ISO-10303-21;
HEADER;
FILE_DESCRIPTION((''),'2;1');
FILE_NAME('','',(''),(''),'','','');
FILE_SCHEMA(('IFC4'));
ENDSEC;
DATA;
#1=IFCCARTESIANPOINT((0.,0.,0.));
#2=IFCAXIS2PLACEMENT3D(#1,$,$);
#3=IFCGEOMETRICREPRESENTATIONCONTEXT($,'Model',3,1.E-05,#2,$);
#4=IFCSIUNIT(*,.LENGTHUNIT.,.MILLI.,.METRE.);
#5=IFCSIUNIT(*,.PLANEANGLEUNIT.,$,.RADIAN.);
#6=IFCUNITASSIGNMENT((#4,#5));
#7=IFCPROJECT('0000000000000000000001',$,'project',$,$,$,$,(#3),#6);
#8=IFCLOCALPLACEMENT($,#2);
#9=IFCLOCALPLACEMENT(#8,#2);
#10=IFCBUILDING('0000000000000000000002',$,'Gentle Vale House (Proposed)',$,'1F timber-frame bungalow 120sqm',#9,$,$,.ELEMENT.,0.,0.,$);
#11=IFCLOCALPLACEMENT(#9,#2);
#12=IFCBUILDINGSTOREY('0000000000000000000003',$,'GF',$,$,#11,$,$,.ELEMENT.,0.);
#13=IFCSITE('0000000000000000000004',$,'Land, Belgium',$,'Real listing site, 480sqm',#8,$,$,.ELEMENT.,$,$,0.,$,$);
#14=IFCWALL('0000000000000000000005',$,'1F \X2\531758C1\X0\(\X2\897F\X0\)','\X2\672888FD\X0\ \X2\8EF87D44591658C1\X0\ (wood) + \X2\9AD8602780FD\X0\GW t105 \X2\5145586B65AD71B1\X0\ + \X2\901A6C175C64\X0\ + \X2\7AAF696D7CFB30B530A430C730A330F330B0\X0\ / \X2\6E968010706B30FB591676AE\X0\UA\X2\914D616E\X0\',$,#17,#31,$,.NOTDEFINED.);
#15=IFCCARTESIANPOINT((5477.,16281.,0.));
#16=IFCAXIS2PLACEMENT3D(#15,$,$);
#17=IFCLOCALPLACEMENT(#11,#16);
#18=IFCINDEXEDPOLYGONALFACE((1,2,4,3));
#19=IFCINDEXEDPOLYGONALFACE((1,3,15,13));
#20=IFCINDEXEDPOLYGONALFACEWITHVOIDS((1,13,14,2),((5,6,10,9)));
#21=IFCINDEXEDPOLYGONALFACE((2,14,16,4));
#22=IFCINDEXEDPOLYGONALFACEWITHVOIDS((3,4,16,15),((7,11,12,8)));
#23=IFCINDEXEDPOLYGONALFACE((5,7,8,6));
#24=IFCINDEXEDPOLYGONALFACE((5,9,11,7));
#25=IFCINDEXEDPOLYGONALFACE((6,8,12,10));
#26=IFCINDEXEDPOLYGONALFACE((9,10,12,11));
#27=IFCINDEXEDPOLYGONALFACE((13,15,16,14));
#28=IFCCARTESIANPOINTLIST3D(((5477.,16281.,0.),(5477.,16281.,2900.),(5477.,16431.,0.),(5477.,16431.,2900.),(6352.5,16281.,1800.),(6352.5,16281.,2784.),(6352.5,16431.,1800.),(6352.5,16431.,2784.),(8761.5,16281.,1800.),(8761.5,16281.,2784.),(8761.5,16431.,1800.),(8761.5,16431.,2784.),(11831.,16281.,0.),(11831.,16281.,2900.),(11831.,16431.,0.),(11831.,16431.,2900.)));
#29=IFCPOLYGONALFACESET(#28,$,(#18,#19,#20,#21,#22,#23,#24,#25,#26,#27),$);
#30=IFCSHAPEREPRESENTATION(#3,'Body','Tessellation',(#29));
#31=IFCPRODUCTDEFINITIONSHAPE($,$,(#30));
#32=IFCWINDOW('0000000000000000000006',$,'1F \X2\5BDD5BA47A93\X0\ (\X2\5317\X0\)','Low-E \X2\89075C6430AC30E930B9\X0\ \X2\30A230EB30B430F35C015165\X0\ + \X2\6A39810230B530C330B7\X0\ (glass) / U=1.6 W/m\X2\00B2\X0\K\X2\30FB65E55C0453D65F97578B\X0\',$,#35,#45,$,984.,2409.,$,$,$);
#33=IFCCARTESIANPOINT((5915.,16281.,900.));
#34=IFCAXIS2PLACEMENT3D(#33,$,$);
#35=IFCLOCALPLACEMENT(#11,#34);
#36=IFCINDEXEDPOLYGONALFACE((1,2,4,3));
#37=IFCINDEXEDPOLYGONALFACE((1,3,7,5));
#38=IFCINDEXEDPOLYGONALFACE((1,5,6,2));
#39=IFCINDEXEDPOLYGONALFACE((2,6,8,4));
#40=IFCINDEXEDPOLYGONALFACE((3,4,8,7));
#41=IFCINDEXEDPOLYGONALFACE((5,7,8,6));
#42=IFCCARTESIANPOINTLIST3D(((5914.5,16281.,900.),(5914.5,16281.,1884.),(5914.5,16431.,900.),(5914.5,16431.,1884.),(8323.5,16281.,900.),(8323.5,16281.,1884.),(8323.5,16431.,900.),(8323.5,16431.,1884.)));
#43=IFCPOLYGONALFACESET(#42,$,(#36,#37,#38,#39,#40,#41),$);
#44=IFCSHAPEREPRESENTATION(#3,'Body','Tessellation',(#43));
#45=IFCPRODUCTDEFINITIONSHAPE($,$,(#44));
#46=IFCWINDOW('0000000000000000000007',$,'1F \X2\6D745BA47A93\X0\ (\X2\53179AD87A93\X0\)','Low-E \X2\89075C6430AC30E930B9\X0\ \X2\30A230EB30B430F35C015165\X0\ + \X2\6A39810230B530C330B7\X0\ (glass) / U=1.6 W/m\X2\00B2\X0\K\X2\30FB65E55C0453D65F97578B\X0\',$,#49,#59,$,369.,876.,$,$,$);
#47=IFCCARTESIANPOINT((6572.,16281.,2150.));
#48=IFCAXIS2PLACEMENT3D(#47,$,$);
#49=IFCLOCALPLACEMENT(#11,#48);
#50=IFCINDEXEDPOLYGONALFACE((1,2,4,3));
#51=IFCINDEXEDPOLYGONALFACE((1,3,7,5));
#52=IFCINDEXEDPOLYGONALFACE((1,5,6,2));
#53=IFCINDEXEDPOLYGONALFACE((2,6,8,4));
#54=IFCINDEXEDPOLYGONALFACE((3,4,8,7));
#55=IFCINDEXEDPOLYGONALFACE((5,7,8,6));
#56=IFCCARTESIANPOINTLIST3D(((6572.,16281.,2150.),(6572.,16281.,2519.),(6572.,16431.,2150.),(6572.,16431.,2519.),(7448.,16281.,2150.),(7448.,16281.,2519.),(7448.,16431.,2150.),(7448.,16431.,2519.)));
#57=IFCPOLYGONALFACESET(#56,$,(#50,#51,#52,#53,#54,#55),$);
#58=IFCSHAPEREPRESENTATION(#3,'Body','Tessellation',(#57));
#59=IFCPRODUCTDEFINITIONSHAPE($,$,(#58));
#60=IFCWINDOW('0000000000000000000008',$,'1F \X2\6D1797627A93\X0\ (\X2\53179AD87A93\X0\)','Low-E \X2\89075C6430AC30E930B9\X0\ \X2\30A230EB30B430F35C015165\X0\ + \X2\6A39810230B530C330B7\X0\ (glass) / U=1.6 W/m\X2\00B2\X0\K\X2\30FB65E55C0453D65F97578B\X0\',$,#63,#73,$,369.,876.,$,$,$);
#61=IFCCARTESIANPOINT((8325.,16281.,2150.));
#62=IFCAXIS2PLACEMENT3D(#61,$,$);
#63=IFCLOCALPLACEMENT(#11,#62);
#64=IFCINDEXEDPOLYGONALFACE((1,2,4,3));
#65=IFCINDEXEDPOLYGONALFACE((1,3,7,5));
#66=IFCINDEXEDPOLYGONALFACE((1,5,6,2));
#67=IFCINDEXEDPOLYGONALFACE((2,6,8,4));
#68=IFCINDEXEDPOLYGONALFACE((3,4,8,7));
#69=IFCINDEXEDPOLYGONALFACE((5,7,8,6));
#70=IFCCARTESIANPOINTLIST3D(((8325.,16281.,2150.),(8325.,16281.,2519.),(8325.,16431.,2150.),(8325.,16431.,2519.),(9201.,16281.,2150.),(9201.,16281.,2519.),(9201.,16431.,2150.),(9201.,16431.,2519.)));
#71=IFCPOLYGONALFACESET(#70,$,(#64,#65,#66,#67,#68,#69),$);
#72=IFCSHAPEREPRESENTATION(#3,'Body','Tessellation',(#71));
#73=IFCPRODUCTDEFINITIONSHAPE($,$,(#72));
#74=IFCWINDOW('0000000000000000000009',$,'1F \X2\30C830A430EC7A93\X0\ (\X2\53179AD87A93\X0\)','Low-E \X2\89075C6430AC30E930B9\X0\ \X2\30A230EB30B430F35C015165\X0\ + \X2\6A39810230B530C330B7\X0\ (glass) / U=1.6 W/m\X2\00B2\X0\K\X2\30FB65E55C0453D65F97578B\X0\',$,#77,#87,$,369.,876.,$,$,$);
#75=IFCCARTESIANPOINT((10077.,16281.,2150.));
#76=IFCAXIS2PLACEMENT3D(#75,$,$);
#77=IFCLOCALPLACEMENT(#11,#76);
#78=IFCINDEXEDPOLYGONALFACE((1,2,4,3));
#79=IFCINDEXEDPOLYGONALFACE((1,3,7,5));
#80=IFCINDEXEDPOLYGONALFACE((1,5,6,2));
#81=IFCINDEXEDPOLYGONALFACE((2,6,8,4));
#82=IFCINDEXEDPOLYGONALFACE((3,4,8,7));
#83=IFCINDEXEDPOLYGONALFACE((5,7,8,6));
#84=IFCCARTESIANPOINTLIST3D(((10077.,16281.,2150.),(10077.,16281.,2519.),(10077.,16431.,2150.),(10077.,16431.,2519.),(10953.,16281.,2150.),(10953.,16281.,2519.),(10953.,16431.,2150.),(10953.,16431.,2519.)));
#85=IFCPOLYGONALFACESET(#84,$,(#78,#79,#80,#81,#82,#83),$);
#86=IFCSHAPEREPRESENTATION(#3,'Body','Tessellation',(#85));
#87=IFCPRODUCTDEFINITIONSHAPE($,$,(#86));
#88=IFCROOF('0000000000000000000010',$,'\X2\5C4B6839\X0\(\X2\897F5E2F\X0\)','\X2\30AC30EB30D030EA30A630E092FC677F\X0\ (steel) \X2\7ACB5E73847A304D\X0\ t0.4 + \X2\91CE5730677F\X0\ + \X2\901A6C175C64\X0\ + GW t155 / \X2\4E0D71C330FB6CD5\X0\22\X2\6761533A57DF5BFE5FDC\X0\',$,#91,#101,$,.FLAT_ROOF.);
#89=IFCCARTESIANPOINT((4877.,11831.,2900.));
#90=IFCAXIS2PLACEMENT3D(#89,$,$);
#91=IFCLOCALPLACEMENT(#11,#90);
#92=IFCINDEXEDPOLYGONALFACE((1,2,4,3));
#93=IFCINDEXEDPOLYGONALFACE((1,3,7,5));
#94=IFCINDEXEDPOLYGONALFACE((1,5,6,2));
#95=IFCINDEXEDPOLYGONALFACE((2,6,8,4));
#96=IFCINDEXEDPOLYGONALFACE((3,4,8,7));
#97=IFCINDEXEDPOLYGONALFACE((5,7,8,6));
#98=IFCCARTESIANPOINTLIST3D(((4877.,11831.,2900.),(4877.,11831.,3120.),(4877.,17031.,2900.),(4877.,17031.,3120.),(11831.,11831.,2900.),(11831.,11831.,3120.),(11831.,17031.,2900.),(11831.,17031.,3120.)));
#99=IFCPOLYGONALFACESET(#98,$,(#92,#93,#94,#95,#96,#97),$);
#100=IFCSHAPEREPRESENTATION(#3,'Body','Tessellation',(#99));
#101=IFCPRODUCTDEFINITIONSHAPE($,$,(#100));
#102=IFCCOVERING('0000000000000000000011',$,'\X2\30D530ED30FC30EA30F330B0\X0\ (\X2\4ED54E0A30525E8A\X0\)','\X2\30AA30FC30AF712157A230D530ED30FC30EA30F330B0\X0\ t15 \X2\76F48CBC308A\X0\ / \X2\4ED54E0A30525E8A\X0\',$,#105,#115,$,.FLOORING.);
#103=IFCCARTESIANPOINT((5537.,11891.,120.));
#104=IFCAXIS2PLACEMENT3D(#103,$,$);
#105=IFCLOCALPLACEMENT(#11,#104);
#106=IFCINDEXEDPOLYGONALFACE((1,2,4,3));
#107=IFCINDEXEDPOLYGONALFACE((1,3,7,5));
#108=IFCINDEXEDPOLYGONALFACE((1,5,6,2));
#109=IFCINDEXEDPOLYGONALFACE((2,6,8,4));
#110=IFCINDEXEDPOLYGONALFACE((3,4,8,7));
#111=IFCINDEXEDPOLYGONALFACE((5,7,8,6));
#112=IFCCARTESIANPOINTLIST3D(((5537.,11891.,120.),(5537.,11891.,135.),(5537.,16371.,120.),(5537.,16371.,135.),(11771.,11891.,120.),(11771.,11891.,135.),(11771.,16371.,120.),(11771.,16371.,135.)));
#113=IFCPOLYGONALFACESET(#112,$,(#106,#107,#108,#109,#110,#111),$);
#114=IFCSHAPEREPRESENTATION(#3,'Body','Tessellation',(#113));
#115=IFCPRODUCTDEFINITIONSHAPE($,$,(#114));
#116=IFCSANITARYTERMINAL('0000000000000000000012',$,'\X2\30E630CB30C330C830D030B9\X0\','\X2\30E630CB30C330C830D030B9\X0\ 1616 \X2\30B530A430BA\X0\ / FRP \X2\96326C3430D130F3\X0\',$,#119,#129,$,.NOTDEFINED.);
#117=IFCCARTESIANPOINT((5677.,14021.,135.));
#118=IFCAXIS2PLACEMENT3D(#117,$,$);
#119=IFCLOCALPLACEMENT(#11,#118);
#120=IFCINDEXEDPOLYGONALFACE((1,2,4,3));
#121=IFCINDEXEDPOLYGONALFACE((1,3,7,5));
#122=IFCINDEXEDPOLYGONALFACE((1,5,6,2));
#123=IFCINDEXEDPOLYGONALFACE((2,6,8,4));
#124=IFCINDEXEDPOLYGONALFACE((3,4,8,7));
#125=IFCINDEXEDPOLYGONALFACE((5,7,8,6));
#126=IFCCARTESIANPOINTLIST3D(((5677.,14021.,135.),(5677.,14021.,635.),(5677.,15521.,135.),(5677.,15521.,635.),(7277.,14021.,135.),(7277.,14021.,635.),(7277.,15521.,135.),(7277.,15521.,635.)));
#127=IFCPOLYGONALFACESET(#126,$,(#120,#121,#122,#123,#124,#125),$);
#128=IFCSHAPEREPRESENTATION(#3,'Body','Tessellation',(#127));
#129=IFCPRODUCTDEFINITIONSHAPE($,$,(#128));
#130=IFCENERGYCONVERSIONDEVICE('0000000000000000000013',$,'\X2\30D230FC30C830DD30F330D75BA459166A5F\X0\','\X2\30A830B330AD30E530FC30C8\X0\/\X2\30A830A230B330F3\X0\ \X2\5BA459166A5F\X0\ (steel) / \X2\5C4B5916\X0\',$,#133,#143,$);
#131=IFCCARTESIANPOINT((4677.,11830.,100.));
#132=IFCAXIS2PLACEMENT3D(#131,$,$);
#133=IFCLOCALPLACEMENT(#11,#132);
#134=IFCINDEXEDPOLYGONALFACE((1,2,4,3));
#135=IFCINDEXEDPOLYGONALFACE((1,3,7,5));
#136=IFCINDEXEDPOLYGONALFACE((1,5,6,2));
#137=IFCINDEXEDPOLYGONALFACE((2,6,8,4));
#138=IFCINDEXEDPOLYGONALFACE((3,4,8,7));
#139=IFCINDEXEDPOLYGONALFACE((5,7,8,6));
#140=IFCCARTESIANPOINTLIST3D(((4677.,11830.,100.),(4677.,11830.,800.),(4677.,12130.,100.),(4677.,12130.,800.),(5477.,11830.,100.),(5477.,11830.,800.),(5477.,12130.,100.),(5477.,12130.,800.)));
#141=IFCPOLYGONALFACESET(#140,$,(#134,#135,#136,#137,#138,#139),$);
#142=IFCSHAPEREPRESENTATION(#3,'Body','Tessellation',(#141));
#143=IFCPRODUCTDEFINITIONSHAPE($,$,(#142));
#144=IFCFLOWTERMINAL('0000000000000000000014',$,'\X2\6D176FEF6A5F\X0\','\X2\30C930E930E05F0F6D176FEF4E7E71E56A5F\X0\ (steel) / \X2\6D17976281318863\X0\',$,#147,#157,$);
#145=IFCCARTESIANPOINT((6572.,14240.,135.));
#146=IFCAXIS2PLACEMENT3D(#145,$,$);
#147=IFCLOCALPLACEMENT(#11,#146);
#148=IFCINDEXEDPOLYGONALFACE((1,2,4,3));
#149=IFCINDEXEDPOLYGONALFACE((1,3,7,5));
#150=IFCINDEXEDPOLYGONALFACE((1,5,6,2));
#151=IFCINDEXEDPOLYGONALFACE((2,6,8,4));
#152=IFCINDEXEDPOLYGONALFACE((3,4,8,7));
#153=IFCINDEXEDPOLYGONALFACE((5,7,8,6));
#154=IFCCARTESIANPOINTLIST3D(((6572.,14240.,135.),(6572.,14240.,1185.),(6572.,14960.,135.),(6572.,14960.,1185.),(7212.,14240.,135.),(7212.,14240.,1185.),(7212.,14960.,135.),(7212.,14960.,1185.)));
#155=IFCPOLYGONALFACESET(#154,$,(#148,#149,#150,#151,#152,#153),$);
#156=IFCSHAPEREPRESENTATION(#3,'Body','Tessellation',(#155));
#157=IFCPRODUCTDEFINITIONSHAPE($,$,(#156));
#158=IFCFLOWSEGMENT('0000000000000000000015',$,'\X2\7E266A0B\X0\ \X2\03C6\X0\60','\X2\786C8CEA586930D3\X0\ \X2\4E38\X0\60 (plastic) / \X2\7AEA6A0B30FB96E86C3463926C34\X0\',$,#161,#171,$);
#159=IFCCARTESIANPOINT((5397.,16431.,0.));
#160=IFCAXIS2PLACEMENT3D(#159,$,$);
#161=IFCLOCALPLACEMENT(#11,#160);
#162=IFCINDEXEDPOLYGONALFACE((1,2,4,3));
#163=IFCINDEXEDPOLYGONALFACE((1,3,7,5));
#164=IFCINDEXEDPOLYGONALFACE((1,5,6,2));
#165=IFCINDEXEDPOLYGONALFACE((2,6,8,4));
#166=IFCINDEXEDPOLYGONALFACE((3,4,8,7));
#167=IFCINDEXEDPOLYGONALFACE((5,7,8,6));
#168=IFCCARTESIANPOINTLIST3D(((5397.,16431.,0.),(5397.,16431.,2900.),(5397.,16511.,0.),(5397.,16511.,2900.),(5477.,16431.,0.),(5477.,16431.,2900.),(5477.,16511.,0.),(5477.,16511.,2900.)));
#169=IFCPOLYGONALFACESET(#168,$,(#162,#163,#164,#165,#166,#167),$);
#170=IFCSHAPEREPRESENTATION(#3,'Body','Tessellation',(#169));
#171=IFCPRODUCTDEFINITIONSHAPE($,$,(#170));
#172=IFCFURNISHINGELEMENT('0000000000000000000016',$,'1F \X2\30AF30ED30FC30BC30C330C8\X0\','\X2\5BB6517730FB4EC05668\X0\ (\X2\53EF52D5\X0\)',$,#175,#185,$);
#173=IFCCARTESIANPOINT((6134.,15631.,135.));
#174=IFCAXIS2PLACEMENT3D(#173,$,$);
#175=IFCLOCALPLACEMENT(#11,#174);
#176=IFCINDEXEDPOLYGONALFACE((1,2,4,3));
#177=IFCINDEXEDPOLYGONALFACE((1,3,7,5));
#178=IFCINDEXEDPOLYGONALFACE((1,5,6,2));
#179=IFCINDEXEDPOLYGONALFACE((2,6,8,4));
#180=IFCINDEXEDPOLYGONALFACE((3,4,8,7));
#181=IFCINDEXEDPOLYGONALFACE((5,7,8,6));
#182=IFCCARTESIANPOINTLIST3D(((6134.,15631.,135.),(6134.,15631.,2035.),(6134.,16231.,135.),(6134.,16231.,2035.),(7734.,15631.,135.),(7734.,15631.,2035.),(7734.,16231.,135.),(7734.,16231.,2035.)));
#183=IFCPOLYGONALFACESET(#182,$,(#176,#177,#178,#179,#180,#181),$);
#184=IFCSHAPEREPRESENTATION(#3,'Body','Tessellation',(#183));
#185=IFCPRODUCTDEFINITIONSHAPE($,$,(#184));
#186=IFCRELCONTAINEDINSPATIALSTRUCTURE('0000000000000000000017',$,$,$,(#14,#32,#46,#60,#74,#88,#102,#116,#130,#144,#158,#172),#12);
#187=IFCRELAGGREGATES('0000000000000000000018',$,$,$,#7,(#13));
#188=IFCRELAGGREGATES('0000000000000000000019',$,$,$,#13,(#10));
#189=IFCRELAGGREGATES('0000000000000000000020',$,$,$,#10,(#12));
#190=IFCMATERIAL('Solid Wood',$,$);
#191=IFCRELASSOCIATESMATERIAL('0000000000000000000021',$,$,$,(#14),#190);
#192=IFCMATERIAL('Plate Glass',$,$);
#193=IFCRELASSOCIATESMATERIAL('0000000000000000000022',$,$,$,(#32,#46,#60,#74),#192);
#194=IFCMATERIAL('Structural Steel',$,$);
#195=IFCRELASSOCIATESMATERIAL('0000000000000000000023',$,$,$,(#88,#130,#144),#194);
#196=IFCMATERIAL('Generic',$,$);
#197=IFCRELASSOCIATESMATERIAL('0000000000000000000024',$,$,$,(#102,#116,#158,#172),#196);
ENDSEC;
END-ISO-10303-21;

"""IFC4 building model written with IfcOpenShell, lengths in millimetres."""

from ifc_helpers import new_model, si_unit, frame, frame_2d, origin, place, context, project, spatial, rectangle, extrude, material, element, fill, save


model = new_model("IFC4")

# Units and contexts
model_context = context("Model", 3, precision=1e-05, world=origin())
ifc_project = project(units=[si_unit("LENGTHUNIT", "METRE", prefix="MILLI"), si_unit("PLANEANGLEUNIT", "RADIAN")], contexts=[model_context])

# Site, building, storey
site_placement = place(None, origin())
site = spatial("IfcSite", under=ifc_project, at=site_placement, Name="Land, Belgium", ObjectType="Real listing site, 480sqm", CompositionType="ELEMENT", RefElevation=0.0)
building_placement = place(site_placement, origin())
building = spatial("IfcBuilding", under=site, at=building_placement, Name="Gentle Vale House (Proposed)", ObjectType="1F timber-frame bungalow 120sqm", CompositionType="ELEMENT", ElevationOfRefHeight=0.0, ElevationOfTerrain=0.0)
storey_placement = place(building_placement, origin())
storey = spatial("IfcBuildingStorey", under=building, at=storey_placement, Name="GF", CompositionType="ELEMENT", Elevation=0.0)

# Shared definitions
ifc_material_1 = material(Name="Solid Wood")

# Wall, openings, windows
wall_1_placement = place(storey_placement, frame((5477.0, 16281.0, 0.0)))
wall_1 = element("IfcWall", 1, at=wall_1_placement, inside=storey, material=ifc_material_1, Name="1F 北壁(西)", Description="木製 軸組外壁 (wood) + 高性能GW t105 充填断熱 + 通気層 + 窯業系サイディング / 準耐火・外皮UA配慮", PredefinedType="NOTDEFINED", context=model_context, shape_type="SweptSolid", body=[
    extrude(rectangle(XDim=6354.0, YDim=150.0, at=frame_2d((3177.0, 75.0))), frame((5477.0, 16281.0, 0.0)), (0.0, 0.0, 1.0), 2900.0),
])
opening_1_placement = place(storey_placement, frame((5915.0, 16281.0, 900.0)))
opening_1 = element("IfcOpeningElement", 2, at=opening_1_placement, cuts=wall_1, PredefinedType="NOTDEFINED", context=model_context, shape_type="SweptSolid", body=[
    extrude(rectangle(XDim=2409.0, YDim=150.0, at=frame_2d((1204.0, 75.0))), frame((5915.0, 16281.0, 900.0)), (0.0, 0.0, 1.0), 984.0),
])
opening_2_placement = place(storey_placement, frame((6572.0, 16281.0, 2150.0)))
opening_2 = element("IfcOpeningElement", 3, at=opening_2_placement, cuts=wall_1, PredefinedType="NOTDEFINED", context=model_context, shape_type="SweptSolid", body=[
    extrude(rectangle(XDim=876.0, YDim=150.0, at=frame_2d((438.0, 75.0))), frame((6572.0, 16281.0, 2150.0)), (0.0, 0.0, 1.0), 369.0),
])
opening_3_placement = place(storey_placement, frame((8325.0, 16281.0, 2150.0)))
opening_3 = element("IfcOpeningElement", 4, at=opening_3_placement, cuts=wall_1, PredefinedType="NOTDEFINED", context=model_context, shape_type="SweptSolid", body=[
    extrude(rectangle(XDim=876.0, YDim=150.0, at=frame_2d((438.0, 75.0))), frame((8325.0, 16281.0, 2150.0)), (0.0, 0.0, 1.0), 369.0),
])
opening_4_placement = place(storey_placement, frame((10077.0, 16281.0, 2150.0)))
opening_4 = element("IfcOpeningElement", 5, at=opening_4_placement, cuts=wall_1, PredefinedType="NOTDEFINED", context=model_context, shape_type="SweptSolid", body=[
    extrude(rectangle(XDim=876.0, YDim=150.0, at=frame_2d((438.0, 75.0))), frame((10077.0, 16281.0, 2150.0)), (0.0, 0.0, 1.0), 369.0),
])
ifc_material_2 = material(Name="Plate Glass")
window_1_placement = place(storey_placement, frame((5915.0, 16281.0, 900.0)))
window_1 = element("IfcWindow", 6, at=window_1_placement, inside=storey, material=ifc_material_2, Name="1F 寝室窓 (北)", Description="Low-E 複層ガラス アルゴン封入 + 樹脂サッシ (glass) / U=1.6 W/m²K・日射取得型", OverallHeight=984.0, OverallWidth=2409.0, context=model_context, shape_type="SweptSolid", body=[
    extrude(rectangle(XDim=2409.0, YDim=150.0, at=frame_2d((1204.0, 75.0))), frame((5915.0, 16281.0, 900.0)), (0.0, 0.0, 1.0), 984.0),
])
fill(opening_1, window_1)
window_2_placement = place(storey_placement, frame((6572.0, 16281.0, 2150.0)))
window_2 = element("IfcWindow", 7, at=window_2_placement, inside=storey, material=ifc_material_2, Name="1F 浴室窓 (北高窓)", Description="Low-E 複層ガラス アルゴン封入 + 樹脂サッシ (glass) / U=1.6 W/m²K・日射取得型", OverallHeight=369.0, OverallWidth=876.0, context=model_context, shape_type="SweptSolid", body=[
    extrude(rectangle(XDim=876.0, YDim=150.0, at=frame_2d((438.0, 75.0))), frame((6572.0, 16281.0, 2150.0)), (0.0, 0.0, 1.0), 369.0),
])
fill(opening_2, window_2)
window_3_placement = place(storey_placement, frame((8325.0, 16281.0, 2150.0)))
window_3 = element("IfcWindow", 8, at=window_3_placement, inside=storey, material=ifc_material_2, Name="1F 洗面窓 (北高窓)", Description="Low-E 複層ガラス アルゴン封入 + 樹脂サッシ (glass) / U=1.6 W/m²K・日射取得型", OverallHeight=369.0, OverallWidth=876.0, context=model_context, shape_type="SweptSolid", body=[
    extrude(rectangle(XDim=876.0, YDim=150.0, at=frame_2d((438.0, 75.0))), frame((8325.0, 16281.0, 2150.0)), (0.0, 0.0, 1.0), 369.0),
])
fill(opening_3, window_3)
window_4_placement = place(storey_placement, frame((10077.0, 16281.0, 2150.0)))
window_4 = element("IfcWindow", 9, at=window_4_placement, inside=storey, material=ifc_material_2, Name="1F トイレ窓 (北高窓)", Description="Low-E 複層ガラス アルゴン封入 + 樹脂サッシ (glass) / U=1.6 W/m²K・日射取得型", OverallHeight=369.0, OverallWidth=876.0, context=model_context, shape_type="SweptSolid", body=[
    extrude(rectangle(XDim=876.0, YDim=150.0, at=frame_2d((438.0, 75.0))), frame((10077.0, 16281.0, 2150.0)), (0.0, 0.0, 1.0), 369.0),
])
fill(opening_4, window_4)

# Roof
ifc_material_3 = material(Name="Structural Steel")
roof_placement = place(storey_placement, frame((4877.0, 11831.0, 2900.0)))
element("IfcRoof", 10, at=roof_placement, inside=storey, material=ifc_material_3, Name="屋根(西帯)", Description="ガルバリウム鋼板 (steel) 立平葺き t0.4 + 野地板 + 通気層 + GW t155 / 不燃・法22条区域対応", PredefinedType="FLAT_ROOF", context=model_context, shape_type="SweptSolid", body=[
    extrude(rectangle(XDim=6954.0, YDim=5200.0, at=frame_2d((3477.0, 2600.0))), frame((4877.0, 11831.0, 2900.0)), (0.0, 0.0, 1.0), 220.0),
])

# Covering
ifc_material_4 = material(Name="Generic")
covering_placement = place(storey_placement, frame((5537.0, 11891.0, 120.0)))
element("IfcCovering", 11, at=covering_placement, inside=storey, material=ifc_material_4, Name="フローリング (仕上げ床)", Description="オーク無垢フローリング t15 直貼り / 仕上げ床", PredefinedType="FLOORING", context=model_context, shape_type="SweptSolid", body=[
    extrude(rectangle(XDim=6234.0, YDim=4480.0, at=frame_2d((3117.0, 2240.0))), frame((5537.0, 11891.0, 120.0)), (0.0, 0.0, 1.0), 15.0),
])

# Sanitary terminal
sanitary_terminal_placement = place(storey_placement, frame((5677.0, 14021.0, 135.0)))
element("IfcSanitaryTerminal", 12, at=sanitary_terminal_placement, inside=storey, material=ifc_material_4, Name="ユニットバス", Description="ユニットバス 1616 サイズ / FRP 防水パン", PredefinedType="NOTDEFINED", context=model_context, shape_type="SweptSolid", body=[
    extrude(rectangle(XDim=1600.0, YDim=1500.0, at=frame_2d((800.0, 750.0))), frame((5677.0, 14021.0, 135.0)), (0.0, 0.0, 1.0), 500.0),
])

# Energy conversion device
energy_conversion_device_placement = place(storey_placement, frame((4677.0, 11830.0, 100.0)))
element("IfcEnergyConversionDevice", 13, at=energy_conversion_device_placement, inside=storey, material=ifc_material_3, Name="ヒートポンプ室外機", Description="エコキュート/エアコン 室外機 (steel) / 屋外", context=model_context, shape_type="SweptSolid", body=[
    extrude(rectangle(XDim=800.0, YDim=300.0, at=frame_2d((400.0, 150.0))), frame((4677.0, 11830.0, 100.0)), (0.0, 0.0, 1.0), 700.0),
])

# Flow terminal
flow_terminal_placement = place(storey_placement, frame((6572.0, 14240.0, 135.0)))
element("IfcFlowTerminal", 14, at=flow_terminal_placement, inside=storey, material=ifc_material_3, Name="洗濯機", Description="ドラム式洗濯乾燥機 (steel) / 洗面脱衣", context=model_context, shape_type="SweptSolid", body=[
    extrude(rectangle(XDim=640.0, YDim=720.0, at=frame_2d((320.0, 360.0))), frame((6572.0, 14240.0, 135.0)), (0.0, 0.0, 1.0), 1050.0),
])

# Flow segment
flow_segment_1_placement = place(storey_placement, frame((5397.0, 16431.0, 0.0)))
element("IfcFlowSegment", 15, at=flow_segment_1_placement, inside=storey, material=ifc_material_4, Name="縦樋 φ60", Description="硬質塩ビ 丸60 (plastic) / 竪樋・雨水排水", context=model_context, shape_type="SweptSolid", body=[
    extrude(rectangle(XDim=80.0, YDim=80.0, at=frame_2d((40.0, 40.0))), frame((5397.0, 16431.0, 0.0)), (0.0, 0.0, 1.0), 2900.0),
])

# Furnishing element
furnishing_1_placement = place(storey_placement, frame((6134.0, 15631.0, 135.0)))
element("IfcFurnishingElement", 16, at=furnishing_1_placement, inside=storey, material=ifc_material_4, Name="1F クローゼット", Description="家具・什器 (可動)", context=model_context, shape_type="SweptSolid", body=[
    extrude(rectangle(XDim=1600.0, YDim=600.0, at=frame_2d((800.0, 300.0))), frame((6134.0, 15631.0, 135.0)), (0.0, 0.0, 1.0), 1900.0),
])

save(model, "model.ifc")
